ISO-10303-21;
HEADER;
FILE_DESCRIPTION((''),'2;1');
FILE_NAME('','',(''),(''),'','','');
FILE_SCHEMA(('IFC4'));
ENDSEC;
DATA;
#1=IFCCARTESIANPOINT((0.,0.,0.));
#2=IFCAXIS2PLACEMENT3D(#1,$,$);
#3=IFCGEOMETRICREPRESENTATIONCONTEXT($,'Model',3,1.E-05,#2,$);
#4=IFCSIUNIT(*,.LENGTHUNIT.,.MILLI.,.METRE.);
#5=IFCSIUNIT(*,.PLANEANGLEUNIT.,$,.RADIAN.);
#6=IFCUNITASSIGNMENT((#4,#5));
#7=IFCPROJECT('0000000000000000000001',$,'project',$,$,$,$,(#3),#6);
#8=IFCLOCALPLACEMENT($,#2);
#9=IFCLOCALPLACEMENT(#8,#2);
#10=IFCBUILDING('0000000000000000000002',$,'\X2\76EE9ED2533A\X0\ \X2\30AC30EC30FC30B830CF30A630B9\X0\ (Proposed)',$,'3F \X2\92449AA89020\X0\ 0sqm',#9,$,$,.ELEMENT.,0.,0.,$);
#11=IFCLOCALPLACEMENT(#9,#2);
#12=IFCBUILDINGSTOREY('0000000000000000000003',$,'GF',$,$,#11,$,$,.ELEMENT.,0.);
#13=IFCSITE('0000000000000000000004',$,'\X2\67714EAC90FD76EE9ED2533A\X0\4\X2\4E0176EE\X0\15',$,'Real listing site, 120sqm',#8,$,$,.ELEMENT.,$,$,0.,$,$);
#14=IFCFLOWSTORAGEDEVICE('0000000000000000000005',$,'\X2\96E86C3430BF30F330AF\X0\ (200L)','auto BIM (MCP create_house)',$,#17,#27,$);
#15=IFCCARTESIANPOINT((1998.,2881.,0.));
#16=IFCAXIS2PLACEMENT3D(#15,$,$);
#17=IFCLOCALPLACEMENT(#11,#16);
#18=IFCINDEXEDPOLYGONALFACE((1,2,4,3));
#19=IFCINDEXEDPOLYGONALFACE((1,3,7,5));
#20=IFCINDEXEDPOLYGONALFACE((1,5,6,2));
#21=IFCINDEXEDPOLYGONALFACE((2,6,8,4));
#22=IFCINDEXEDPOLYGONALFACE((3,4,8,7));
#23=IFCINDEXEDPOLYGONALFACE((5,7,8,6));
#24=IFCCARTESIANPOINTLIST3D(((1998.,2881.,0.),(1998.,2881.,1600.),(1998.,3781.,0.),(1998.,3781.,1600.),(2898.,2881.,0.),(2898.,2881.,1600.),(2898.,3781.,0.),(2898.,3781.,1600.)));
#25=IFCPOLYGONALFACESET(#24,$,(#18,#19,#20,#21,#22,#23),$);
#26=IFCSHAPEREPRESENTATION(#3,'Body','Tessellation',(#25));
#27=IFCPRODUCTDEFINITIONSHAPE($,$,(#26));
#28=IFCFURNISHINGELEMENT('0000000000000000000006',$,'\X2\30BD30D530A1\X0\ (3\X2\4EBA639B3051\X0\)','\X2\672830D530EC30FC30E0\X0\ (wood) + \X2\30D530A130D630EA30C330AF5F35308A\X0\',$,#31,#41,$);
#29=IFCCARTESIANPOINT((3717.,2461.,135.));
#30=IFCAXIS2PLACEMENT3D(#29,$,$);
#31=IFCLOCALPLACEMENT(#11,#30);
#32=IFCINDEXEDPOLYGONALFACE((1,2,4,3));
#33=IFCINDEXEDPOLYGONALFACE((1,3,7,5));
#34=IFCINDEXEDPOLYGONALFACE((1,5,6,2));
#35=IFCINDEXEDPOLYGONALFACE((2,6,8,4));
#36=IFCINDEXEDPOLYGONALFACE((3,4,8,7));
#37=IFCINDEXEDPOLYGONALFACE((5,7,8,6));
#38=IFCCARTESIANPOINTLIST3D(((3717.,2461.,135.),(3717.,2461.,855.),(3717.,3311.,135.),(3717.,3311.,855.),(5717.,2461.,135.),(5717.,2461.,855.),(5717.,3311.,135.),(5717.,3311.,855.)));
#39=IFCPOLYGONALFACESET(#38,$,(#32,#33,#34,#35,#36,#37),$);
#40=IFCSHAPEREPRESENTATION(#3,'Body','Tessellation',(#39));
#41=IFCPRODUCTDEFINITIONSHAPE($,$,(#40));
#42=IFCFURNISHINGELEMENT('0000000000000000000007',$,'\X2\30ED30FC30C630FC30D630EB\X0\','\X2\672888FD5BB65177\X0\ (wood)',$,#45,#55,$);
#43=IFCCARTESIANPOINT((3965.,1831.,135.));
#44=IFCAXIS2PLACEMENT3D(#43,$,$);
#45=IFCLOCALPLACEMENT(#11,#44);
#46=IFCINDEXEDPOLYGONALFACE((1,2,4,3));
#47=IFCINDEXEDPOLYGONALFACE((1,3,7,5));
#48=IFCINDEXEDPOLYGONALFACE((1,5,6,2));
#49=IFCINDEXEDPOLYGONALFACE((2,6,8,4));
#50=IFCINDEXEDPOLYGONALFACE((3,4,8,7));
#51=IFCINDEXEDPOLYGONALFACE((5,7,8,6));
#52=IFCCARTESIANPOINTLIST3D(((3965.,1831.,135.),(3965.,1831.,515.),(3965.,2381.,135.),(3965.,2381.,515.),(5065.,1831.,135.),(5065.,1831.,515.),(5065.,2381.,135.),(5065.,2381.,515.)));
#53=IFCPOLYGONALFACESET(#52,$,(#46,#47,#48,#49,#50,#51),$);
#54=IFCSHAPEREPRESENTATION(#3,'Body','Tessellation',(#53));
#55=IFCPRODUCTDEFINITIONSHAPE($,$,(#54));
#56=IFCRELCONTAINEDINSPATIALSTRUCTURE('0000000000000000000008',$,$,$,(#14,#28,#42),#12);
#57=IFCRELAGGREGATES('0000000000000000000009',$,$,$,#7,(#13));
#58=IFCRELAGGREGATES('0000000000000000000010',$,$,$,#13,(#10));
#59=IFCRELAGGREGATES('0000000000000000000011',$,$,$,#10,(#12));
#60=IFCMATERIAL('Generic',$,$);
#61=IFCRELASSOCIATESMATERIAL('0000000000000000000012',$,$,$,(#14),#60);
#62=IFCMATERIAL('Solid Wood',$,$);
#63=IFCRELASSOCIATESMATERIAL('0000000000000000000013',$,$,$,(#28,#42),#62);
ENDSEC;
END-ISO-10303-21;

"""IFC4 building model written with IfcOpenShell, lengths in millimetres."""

from ifc_helpers import new_model, si_unit, frame, frame_2d, origin, place, context, project, spatial, rectangle, extrude, material, element, save


model = new_model("IFC4")

# Units and contexts
model_context = context("Model", 3, precision=1e-05, world=origin())
ifc_project = project(units=[si_unit("LENGTHUNIT", "METRE", prefix="MILLI"), si_unit("PLANEANGLEUNIT", "RADIAN")], contexts=[model_context])

# Site, building, storey
site_placement = place(None, origin())
site = spatial("IfcSite", under=ifc_project, at=site_placement, Name="東京都目黒区4丁目15", ObjectType="Real listing site, 120sqm", CompositionType="ELEMENT", RefElevation=0.0)
building_placement = place(site_placement, origin())
building = spatial("IfcBuilding", under=site, at=building_placement, Name="目黒区 ガレージハウス (Proposed)", ObjectType="3F 鉄骨造 0sqm", CompositionType="ELEMENT", ElevationOfRefHeight=0.0, ElevationOfTerrain=0.0)
storey_placement = place(building_placement, origin())
storey = spatial("IfcBuildingStorey", under=building, at=storey_placement, Name="GF", CompositionType="ELEMENT", Elevation=0.0)

# Shared definitions
ifc_material_1 = material(Name="Solid Wood")

# Shared definitions
ifc_material_2 = material(Name="Generic")

# Flow storage device
flow_storage_device_placement = place(storey_placement, frame((1998.0, 2881.0, 0.0)))
element("IfcFlowStorageDevice", 1, at=flow_storage_device_placement, inside=storey, material=ifc_material_2, Name="雨水タンク (200L)", Description="auto BIM (MCP create_house)", context=model_context, shape_type="SweptSolid", body=[
    extrude(rectangle(XDim=900.0, YDim=900.0, at=frame_2d((450.0, 450.0))), frame((1998.0, 2881.0, 0.0)), (0.0, 0.0, 1.0), 1600.0),
])

# Furnishing elements
furnishing_1_placement = place(storey_placement, frame((3717.0, 2461.0, 135.0)))
element("IfcFurnishingElement", 2, at=furnishing_1_placement, inside=storey, material=ifc_material_1, Name="ソファ (3人掛け)", Description="木フレーム (wood) + ファブリック張り", context=model_context, shape_type="SweptSolid", body=[
    extrude(rectangle(XDim=2000.0, YDim=850.0, at=frame_2d((1000.0, 425.0))), frame((3717.0, 2461.0, 135.0)), (0.0, 0.0, 1.0), 720.0),
])
furnishing_2_placement = place(storey_placement, frame((3965.0, 1831.0, 135.0)))
element("IfcFurnishingElement", 3, at=furnishing_2_placement, inside=storey, material=ifc_material_1, Name="ローテーブル", Description="木製家具 (wood)", context=model_context, shape_type="SweptSolid", body=[
    extrude(rectangle(XDim=1100.0, YDim=550.0, at=frame_2d((550.0, 275.0))), frame((3965.0, 1831.0, 135.0)), (0.0, 0.0, 1.0), 380.0),
])

save(model, "model.ifc")
